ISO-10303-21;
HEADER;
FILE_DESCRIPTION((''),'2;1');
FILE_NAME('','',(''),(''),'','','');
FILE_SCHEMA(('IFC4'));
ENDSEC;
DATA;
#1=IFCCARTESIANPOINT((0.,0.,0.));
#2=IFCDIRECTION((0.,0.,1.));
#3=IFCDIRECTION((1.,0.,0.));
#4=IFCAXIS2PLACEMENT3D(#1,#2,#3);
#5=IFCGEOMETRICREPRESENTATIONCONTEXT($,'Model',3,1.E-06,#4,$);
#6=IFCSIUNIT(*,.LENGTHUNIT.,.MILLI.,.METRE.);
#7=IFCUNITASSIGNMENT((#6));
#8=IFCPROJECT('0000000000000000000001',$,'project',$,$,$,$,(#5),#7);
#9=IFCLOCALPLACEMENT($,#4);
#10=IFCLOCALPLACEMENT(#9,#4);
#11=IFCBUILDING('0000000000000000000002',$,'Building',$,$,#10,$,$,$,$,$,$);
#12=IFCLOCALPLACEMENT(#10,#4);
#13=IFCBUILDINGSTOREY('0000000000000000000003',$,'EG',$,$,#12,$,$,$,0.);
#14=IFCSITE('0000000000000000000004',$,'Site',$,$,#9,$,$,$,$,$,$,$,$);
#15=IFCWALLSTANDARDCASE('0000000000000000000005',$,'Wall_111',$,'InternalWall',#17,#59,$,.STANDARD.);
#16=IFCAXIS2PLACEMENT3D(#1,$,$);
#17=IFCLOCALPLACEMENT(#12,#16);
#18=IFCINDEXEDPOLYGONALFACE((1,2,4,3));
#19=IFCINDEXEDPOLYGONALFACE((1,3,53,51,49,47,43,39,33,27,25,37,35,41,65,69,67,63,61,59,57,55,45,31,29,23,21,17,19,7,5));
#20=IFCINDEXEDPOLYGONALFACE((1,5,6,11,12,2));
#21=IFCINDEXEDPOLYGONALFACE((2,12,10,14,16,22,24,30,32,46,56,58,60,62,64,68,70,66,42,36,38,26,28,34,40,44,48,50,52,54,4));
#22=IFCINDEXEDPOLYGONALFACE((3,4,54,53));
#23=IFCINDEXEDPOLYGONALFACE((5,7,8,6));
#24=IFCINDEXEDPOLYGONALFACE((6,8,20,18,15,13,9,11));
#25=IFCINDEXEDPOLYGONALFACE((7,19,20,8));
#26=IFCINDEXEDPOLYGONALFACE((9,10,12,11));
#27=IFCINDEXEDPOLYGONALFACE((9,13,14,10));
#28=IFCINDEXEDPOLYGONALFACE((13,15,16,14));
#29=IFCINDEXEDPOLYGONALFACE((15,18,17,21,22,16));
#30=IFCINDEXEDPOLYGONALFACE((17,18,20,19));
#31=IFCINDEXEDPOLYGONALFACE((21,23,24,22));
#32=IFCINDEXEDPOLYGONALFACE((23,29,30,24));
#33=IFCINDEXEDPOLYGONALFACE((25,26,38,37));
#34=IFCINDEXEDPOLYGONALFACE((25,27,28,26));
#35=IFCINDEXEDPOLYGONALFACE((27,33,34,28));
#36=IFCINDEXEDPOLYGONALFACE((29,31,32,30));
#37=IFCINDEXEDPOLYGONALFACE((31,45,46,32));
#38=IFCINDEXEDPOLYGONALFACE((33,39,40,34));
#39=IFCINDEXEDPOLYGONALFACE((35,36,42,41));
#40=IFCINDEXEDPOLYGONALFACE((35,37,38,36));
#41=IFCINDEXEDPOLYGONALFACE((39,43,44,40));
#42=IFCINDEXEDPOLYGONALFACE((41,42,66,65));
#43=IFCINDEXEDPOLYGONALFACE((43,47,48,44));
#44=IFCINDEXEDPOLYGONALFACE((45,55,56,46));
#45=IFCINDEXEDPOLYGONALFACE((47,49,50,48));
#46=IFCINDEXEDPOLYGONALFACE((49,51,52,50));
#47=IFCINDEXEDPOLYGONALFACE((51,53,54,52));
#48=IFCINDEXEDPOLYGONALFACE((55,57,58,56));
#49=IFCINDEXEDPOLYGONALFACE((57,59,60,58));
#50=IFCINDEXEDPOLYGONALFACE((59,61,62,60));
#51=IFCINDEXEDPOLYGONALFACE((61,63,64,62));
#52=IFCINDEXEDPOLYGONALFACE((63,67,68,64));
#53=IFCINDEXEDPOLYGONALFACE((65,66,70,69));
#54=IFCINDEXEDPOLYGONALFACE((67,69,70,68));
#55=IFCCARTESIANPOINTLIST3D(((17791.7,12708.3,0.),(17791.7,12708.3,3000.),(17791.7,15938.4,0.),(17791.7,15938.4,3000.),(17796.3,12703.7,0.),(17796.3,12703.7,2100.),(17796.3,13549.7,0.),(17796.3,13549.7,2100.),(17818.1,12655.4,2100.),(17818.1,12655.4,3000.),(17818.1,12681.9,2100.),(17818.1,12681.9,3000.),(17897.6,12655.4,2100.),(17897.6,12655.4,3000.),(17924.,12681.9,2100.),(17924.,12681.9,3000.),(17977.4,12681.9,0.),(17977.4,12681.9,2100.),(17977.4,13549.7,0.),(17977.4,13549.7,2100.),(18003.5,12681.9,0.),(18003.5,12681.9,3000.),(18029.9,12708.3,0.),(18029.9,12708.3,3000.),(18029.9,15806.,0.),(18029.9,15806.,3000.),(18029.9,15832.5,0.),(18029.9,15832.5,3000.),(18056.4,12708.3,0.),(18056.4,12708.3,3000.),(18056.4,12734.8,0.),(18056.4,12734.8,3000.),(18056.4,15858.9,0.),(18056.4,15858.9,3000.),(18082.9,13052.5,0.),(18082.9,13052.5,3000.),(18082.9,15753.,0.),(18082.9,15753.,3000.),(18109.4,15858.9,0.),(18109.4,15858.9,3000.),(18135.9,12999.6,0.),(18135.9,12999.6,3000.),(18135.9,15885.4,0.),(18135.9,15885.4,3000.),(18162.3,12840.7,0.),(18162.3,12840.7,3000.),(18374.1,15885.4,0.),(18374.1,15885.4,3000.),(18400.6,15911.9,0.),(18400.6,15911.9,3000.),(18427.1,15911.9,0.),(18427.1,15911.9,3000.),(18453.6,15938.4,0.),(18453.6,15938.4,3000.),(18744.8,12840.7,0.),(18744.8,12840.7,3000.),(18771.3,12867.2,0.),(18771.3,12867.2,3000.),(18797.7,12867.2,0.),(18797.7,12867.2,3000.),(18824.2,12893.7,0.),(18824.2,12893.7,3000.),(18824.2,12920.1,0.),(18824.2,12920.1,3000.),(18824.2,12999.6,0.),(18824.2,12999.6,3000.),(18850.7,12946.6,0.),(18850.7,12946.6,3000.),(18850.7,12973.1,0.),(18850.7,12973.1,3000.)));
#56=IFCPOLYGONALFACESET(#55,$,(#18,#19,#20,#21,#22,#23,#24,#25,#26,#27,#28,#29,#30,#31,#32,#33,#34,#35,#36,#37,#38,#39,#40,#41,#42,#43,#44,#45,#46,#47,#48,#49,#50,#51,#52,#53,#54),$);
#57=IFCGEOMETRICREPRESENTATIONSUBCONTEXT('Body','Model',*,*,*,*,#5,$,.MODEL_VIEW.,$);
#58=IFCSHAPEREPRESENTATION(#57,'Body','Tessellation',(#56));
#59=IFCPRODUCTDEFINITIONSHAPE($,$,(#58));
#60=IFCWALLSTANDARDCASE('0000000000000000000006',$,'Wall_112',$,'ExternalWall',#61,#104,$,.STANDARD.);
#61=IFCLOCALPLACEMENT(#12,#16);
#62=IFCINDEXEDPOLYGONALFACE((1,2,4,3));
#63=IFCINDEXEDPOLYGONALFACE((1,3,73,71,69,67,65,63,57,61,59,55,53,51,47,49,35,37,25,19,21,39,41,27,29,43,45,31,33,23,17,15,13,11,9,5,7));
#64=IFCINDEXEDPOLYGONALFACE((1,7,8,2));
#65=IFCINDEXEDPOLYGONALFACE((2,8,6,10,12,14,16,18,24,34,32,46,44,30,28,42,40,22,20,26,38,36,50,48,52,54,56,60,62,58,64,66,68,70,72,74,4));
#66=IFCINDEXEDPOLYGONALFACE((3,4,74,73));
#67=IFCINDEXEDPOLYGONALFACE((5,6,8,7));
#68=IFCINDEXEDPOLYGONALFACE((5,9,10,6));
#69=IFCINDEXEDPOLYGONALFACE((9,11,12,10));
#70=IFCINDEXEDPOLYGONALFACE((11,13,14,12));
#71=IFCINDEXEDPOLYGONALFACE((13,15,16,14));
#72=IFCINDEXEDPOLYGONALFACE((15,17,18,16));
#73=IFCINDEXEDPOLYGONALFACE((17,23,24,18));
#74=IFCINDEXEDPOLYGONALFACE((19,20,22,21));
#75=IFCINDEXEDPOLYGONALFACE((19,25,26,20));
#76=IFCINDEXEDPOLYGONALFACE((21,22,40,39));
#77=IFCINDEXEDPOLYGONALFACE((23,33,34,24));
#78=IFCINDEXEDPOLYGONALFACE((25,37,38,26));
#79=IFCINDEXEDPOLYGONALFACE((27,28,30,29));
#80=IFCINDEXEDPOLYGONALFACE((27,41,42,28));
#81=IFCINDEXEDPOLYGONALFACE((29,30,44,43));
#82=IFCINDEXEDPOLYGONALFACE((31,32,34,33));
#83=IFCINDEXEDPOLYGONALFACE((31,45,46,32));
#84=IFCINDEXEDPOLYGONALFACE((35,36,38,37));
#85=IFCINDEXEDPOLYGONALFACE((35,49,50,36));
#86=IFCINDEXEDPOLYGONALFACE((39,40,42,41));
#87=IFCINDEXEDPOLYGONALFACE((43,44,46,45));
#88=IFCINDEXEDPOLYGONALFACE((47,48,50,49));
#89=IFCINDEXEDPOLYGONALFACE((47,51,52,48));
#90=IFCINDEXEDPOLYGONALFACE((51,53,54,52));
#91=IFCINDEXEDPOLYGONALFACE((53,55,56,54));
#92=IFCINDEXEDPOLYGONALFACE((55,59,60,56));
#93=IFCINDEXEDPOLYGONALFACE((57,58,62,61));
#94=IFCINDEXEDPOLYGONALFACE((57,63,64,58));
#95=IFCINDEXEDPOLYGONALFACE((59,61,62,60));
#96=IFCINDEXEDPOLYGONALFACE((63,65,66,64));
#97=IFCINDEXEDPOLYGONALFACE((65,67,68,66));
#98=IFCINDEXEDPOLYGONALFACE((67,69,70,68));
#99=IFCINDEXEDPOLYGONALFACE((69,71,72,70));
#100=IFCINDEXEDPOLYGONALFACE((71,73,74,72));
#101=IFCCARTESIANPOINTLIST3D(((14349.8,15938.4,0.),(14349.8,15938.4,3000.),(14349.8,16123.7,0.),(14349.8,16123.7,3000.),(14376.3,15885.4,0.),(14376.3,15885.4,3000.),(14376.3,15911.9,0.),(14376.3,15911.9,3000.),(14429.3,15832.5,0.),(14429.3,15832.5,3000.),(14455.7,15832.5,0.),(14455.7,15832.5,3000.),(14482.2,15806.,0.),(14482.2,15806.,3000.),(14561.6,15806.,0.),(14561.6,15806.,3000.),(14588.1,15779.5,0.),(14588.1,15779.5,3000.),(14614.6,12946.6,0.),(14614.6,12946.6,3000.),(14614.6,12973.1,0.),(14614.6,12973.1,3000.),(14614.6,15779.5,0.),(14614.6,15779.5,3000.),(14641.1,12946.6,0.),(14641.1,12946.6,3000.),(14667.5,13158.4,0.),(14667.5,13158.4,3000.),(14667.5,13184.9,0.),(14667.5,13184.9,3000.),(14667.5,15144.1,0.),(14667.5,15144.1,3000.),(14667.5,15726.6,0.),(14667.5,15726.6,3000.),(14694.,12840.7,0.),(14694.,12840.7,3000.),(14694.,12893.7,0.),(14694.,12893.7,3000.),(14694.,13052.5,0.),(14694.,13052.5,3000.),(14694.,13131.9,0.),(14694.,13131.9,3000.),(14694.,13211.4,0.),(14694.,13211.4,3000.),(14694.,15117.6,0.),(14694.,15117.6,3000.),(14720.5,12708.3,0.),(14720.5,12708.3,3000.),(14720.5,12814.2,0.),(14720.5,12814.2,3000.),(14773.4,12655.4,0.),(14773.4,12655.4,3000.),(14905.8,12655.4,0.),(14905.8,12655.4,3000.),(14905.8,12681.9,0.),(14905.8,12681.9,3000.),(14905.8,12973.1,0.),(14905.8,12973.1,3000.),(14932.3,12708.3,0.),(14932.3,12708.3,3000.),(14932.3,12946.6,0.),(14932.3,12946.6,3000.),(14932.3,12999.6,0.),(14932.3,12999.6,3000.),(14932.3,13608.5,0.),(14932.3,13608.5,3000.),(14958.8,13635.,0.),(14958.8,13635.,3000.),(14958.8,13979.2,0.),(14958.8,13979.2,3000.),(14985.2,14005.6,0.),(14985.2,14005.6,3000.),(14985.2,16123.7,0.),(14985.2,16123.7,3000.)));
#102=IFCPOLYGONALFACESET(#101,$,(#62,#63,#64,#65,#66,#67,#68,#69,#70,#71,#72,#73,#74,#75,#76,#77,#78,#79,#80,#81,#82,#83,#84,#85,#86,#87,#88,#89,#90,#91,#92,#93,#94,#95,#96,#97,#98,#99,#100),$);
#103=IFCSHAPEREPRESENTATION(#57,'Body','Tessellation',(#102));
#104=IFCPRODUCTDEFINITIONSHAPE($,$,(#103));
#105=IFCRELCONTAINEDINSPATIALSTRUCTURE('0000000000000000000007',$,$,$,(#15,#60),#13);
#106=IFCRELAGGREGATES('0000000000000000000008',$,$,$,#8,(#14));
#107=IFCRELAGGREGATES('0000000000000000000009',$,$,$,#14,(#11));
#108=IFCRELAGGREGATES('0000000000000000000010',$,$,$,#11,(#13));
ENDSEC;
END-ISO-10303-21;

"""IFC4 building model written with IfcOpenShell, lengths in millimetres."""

from ifc_helpers import new_model, si_unit, frame, origin_with_axes, place, context, subcontext, project, spatial, polyline, rectangle, outline, extrude, element, save


model = new_model("IFC4")

# Units and contexts
model_context = context("Model", 3, precision=1e-06, world=origin_with_axes())
body_context = subcontext(model_context, "Body", "Model", "MODEL_VIEW")
ifc_project = project(units=[si_unit("LENGTHUNIT", "METRE", prefix="MILLI")], contexts=[model_context])

# Site, building, storey
site_placement = place(None, origin_with_axes())
site = spatial("IfcSite", under=ifc_project, at=site_placement, Name="Site")
building_placement = place(site_placement, origin_with_axes())
building = spatial("IfcBuilding", under=site, at=building_placement, Name="Building")
storey_placement = place(building_placement, origin_with_axes())
storey = spatial("IfcBuildingStorey", under=building, at=storey_placement, Name="EG", Elevation=0.0)

# Wall, opening
wall_1_placement = place(storey_placement, origin_with_axes())
wall_1 = element("IfcWallStandardCase", 1, at=wall_1_placement, inside=storey, Name="Wall_111", ObjectType="InternalWall", PredefinedType="STANDARD", context=body_context, shape_type="SweptSolid", body=[
    extrude(outline(polyline([(17818.1, 12655.4, 0.0), (17818.1, 12681.9, 0.0), (17791.7, 12708.3, 0.0), (17791.7, 15938.4, 0.0), (18453.6, 15938.4, 0.0), (18427.1, 15911.9, 0.0), (18400.6, 15911.9, 0.0), (18374.1, 15885.4, 0.0), (18135.9, 15885.4, 0.0), (18109.4, 15858.9, 0.0), (18056.4, 15858.9, 0.0), (18029.9, 15832.5, 0.0), (18029.9, 15806.0, 0.0), (18082.9, 15753.0, 0.0), (18082.9, 13052.5, 0.0), (18135.9, 12999.6, 0.0), (18824.2, 12999.6, 0.0), (18850.7, 12973.1, 0.0), (18850.7, 12946.6, 0.0), (18824.2, 12920.1, 0.0), (18824.2, 12893.7, 0.0), (18797.7, 12867.2, 0.0), (18771.3, 12867.2, 0.0), (18744.8, 12840.7, 0.0), (18162.3, 12840.7, 0.0), (18056.4, 12734.8, 0.0), (18056.4, 12708.3, 0.0), (18029.9, 12708.3, 0.0), (18003.5, 12681.9, 0.0), (17924.0, 12681.9, 0.0), (17897.6, 12655.4, 0.0), (17818.1, 12655.4, 0.0)])), origin_with_axes(), (0.0, 0.0, 1.0), 3000.0),
])
opening_1_placement = place(wall_1_placement, origin_with_axes())
element("IfcOpeningElement", 2, at=opening_1_placement, inside=storey, cuts=wall_1, context=body_context, shape_type="SweptSolid", body=[
    extrude(rectangle(XDim=1440.7, YDim=181.1), frame((17886.8, 12829.3, 0.0), z_axis=(0.0, 0.0, 1.0), x_axis=(0.0, 1.0, 0.0)), (0.0, 0.0, 1.0), 2100.0),
])

# Wall
for number, where, z_axis, x_axis, name in (
    (3, (0.0, 0.0, 0.0), (0.0, 0.0, 1.0), (1.0, 0.0, 0.0), "Wall_112"),
):
    element("IfcWallStandardCase", number, at=place(storey_placement, frame(where, z_axis=z_axis, x_axis=x_axis)), inside=storey, Name=name, ObjectType="ExternalWall", PredefinedType="STANDARD", context=body_context, shape_type="SweptSolid", body=[
        extrude(outline(polyline([(14773.4, 12655.4, 0.0), (14720.5, 12708.3, 0.0), (14720.5, 12814.2, 0.0), (14694.0, 12840.7, 0.0), (14694.0, 12893.7, 0.0), (14641.1, 12946.6, 0.0), (14614.6, 12946.6, 0.0), (14614.6, 12973.1, 0.0), (14694.0, 13052.5, 0.0), (14694.0, 13131.9, 0.0), (14667.5, 13158.4, 0.0), (14667.5, 13184.9, 0.0), (14694.0, 13211.4, 0.0), (14694.0, 15117.6, 0.0), (14667.5, 15144.1, 0.0), (14667.5, 15726.6, 0.0), (14614.6, 15779.5, 0.0), (14588.1, 15779.5, 0.0), (14561.6, 15806.0, 0.0), (14482.2, 15806.0, 0.0), (14455.7, 15832.5, 0.0), (14429.3, 15832.5, 0.0), (14376.3, 15885.4, 0.0), (14376.3, 15911.9, 0.0), (14349.8, 15938.4, 0.0), (14349.8, 16123.7, 0.0), (14985.2, 16123.7, 0.0), (14985.2, 14005.6, 0.0), (14958.8, 13979.2, 0.0), (14958.8, 13635.0, 0.0), (14932.3, 13608.5, 0.0), (14932.3, 12999.6, 0.0), (14905.8, 12973.1, 0.0), (14932.3, 12946.6, 0.0), (14932.3, 12708.3, 0.0), (14905.8, 12681.9, 0.0), (14905.8, 12655.4, 0.0), (14773.4, 12655.4, 0.0)])), origin_with_axes(), (0.0, 0.0, 1.0), 3000.0),
    ])

save(model, "model.ifc")
